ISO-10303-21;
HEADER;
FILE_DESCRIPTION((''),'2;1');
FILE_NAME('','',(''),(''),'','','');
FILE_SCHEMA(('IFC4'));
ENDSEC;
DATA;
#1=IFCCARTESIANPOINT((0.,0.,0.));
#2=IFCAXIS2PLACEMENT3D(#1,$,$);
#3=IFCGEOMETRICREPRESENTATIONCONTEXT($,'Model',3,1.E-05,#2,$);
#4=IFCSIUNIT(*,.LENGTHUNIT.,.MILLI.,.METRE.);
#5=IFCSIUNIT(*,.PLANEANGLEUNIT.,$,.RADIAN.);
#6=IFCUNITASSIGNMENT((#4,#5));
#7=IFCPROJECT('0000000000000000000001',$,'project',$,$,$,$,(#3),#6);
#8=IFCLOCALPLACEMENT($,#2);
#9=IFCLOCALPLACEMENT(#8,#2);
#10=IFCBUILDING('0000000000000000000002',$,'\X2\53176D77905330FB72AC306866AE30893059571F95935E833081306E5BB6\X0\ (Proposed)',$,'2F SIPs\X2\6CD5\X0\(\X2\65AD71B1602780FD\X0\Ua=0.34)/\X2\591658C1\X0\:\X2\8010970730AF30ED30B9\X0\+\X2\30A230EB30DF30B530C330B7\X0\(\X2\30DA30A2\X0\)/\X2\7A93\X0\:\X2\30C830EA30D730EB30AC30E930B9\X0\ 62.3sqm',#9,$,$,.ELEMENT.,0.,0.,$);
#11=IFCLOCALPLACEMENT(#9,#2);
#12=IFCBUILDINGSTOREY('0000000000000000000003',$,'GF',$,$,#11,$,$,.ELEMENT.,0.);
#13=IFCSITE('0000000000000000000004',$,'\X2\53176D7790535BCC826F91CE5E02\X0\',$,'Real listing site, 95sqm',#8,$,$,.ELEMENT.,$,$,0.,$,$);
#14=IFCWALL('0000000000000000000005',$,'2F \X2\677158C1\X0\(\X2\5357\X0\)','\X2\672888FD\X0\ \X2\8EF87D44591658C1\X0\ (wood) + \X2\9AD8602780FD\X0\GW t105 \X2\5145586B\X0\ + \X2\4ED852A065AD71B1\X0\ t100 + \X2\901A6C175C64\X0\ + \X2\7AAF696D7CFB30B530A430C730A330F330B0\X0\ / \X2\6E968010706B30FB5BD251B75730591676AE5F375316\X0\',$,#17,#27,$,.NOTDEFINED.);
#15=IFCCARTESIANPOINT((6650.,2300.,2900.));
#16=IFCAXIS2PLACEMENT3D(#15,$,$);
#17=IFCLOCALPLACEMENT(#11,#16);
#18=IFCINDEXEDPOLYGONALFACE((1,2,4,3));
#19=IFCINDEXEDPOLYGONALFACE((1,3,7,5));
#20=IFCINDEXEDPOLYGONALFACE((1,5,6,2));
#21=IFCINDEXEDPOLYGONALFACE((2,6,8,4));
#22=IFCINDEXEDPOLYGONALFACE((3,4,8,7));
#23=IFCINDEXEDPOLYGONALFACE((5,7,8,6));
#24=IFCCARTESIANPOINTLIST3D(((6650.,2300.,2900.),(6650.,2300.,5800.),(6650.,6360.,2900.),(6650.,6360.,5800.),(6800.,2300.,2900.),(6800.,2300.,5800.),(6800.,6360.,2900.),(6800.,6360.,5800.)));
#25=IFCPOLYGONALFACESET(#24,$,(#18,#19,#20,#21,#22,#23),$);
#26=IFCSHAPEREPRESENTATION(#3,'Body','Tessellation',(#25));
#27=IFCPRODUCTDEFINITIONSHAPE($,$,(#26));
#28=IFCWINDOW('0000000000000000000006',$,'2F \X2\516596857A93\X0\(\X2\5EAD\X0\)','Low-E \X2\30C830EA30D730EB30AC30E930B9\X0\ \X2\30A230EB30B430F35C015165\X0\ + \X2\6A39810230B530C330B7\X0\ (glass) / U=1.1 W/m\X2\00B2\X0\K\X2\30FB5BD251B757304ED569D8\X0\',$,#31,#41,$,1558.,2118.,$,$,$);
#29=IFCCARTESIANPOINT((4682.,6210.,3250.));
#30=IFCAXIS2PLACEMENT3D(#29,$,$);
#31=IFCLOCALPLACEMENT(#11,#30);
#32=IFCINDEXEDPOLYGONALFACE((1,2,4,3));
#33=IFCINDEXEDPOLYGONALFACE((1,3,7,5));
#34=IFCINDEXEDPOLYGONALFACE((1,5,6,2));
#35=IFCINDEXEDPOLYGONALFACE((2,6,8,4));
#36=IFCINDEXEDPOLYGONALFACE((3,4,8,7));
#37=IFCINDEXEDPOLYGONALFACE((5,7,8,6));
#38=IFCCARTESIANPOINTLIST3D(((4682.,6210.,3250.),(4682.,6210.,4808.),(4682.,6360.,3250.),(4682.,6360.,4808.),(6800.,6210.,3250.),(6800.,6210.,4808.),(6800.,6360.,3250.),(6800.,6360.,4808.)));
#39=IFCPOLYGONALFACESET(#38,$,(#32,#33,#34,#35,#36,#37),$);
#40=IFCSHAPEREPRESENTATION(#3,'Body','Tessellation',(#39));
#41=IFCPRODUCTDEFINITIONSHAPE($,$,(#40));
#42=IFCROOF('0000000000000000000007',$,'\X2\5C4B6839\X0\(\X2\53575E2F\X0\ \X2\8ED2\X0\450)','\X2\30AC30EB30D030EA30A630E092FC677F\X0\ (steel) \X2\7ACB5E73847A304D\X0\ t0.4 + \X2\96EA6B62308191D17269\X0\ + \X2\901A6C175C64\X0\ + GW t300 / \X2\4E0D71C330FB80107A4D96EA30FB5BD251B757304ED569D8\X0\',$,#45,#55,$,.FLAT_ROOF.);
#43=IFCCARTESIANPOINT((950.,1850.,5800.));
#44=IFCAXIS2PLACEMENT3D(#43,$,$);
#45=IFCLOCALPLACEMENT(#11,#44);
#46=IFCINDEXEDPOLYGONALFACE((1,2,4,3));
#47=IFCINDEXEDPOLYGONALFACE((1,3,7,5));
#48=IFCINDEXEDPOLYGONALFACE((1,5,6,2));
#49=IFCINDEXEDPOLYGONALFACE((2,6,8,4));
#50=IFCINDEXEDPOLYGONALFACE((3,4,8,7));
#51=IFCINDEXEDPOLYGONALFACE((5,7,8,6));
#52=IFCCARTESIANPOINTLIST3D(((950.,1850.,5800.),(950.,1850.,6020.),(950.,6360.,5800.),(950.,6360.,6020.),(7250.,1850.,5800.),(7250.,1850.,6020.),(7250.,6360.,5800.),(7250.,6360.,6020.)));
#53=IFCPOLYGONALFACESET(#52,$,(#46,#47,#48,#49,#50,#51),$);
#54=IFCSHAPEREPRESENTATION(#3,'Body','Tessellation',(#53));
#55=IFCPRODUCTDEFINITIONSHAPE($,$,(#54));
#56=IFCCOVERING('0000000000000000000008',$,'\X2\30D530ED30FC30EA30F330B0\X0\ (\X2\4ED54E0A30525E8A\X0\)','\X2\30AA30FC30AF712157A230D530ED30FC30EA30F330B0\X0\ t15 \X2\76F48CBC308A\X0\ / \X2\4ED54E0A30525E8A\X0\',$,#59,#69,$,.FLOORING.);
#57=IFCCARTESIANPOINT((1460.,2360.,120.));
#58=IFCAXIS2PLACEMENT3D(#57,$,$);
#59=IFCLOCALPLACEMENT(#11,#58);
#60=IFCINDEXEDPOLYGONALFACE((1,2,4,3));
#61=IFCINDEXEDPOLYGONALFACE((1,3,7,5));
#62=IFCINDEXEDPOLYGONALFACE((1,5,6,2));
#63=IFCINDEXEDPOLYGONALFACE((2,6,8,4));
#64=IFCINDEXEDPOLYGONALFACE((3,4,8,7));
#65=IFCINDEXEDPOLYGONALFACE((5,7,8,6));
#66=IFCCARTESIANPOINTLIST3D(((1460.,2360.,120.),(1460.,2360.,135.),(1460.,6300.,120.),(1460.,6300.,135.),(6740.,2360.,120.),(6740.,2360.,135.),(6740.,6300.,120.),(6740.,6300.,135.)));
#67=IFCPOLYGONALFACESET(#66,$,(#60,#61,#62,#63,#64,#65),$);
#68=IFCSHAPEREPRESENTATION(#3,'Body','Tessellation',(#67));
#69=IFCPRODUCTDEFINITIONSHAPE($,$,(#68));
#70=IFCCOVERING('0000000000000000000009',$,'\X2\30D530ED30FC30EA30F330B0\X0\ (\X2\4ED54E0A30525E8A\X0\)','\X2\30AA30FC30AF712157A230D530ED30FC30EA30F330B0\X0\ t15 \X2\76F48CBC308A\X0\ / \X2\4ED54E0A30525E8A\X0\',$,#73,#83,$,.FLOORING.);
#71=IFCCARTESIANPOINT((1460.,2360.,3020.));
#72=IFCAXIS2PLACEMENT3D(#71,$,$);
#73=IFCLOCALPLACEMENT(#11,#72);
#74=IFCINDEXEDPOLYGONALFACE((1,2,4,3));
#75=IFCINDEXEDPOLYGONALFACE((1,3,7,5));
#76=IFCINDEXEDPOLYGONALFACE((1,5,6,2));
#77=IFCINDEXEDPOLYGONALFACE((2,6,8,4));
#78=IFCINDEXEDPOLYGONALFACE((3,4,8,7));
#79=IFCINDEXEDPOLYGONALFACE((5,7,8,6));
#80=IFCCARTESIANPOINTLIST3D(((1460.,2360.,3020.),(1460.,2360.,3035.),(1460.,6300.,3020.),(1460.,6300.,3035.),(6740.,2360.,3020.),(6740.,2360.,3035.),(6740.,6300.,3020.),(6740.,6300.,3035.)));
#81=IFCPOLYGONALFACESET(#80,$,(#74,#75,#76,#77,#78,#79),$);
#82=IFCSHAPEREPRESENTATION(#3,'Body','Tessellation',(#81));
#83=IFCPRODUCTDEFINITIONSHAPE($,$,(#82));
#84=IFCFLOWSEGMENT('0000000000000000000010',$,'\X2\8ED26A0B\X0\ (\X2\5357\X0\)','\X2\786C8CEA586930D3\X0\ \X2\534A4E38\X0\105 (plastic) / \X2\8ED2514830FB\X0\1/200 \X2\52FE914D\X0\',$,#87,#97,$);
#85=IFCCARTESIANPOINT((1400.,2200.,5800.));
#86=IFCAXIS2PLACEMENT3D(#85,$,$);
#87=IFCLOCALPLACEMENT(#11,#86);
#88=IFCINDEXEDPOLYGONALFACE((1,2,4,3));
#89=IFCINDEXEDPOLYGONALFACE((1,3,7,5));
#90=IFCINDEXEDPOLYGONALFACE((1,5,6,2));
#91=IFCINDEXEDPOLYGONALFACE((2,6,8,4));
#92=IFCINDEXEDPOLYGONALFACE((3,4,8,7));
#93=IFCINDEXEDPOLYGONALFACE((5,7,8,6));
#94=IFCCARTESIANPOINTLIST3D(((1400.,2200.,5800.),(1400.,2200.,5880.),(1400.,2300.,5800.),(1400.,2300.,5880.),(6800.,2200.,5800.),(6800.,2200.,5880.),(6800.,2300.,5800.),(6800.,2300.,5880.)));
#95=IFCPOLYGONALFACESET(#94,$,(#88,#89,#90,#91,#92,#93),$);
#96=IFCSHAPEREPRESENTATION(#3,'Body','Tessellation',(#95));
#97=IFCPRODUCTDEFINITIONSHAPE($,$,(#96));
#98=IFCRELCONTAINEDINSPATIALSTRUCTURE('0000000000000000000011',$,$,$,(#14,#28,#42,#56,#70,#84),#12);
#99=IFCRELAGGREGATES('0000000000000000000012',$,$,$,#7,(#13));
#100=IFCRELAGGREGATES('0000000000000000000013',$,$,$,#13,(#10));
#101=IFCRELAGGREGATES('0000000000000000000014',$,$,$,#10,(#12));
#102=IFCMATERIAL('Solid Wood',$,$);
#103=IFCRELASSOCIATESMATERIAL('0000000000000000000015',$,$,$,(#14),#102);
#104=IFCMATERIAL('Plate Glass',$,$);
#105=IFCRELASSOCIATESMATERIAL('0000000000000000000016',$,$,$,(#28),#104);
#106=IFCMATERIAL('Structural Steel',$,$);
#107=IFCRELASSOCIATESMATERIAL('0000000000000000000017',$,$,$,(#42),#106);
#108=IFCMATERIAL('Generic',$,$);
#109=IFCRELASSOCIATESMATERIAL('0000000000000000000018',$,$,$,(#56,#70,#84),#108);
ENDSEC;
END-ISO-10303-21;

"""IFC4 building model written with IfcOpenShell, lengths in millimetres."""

from ifc_helpers import new_model, si_unit, frame, frame_2d, origin, place, context, project, spatial, rectangle, extrude, material, element, fill, save


model = new_model("IFC4")

# Units and contexts
model_context = context("Model", 3, precision=1e-05, world=origin())
ifc_project = project(units=[si_unit("LENGTHUNIT", "METRE", prefix="MILLI"), si_unit("PLANEANGLEUNIT", "RADIAN")], contexts=[model_context])

# Site, building, storey
site_placement = place(None, origin())
site = spatial("IfcSite", under=ifc_project, at=site_placement, Name="北海道富良野市", ObjectType="Real listing site, 95sqm", CompositionType="ELEMENT", RefElevation=0.0)
building_placement = place(site_placement, origin())
building = spatial("IfcBuilding", under=site, at=building_placement, Name="北海道・犬と暮らす土間広めの家 (Proposed)", ObjectType="2F SIPs法(断熱性能Ua=0.34)/外壁:耐震クロス+アルミサッシ(ペア)/窓:トリプルガラス 62.3sqm", CompositionType="ELEMENT", ElevationOfRefHeight=0.0, ElevationOfTerrain=0.0)
storey_placement = place(building_placement, origin())
storey = spatial("IfcBuildingStorey", under=building, at=storey_placement, Name="GF", CompositionType="ELEMENT", Elevation=0.0)

# Shared definitions
ifc_material_1 = material(Name="Solid Wood")

# Wall, opening, window
ifc_material_2 = material(Name="Plate Glass")
wall_1_placement = place(storey_placement, frame((6650.0, 2300.0, 2900.0)))
wall_1 = element("IfcWall", 1, at=wall_1_placement, inside=storey, material=ifc_material_1, Name="2F 東壁(南)", Description="木製 軸組外壁 (wood) + 高性能GW t105 充填 + 付加断熱 t100 + 通気層 + 窯業系サイディング / 準耐火・寒冷地外皮強化", PredefinedType="NOTDEFINED", context=model_context, shape_type="SweptSolid", body=[
    extrude(rectangle(XDim=150.0, YDim=4060.0, at=frame_2d((75.0, 2030.0))), frame((6650.0, 2300.0, 2900.0)), (0.0, 0.0, 1.0), 2900.0),
])
opening_1_placement = place(storey_placement, frame((4682.0, 6210.0, 3250.0)))
opening_1 = element("IfcOpeningElement", 2, at=opening_1_placement, cuts=wall_1, PredefinedType="NOTDEFINED", context=model_context, shape_type="SweptSolid", body=[
    extrude(rectangle(XDim=2118.0, YDim=150.0, at=frame_2d((1059.0, 75.0))), frame((4682.0, 6210.0, 3250.0)), (0.0, 0.0, 1.0), 1558.0),
])
window_1_placement = place(storey_placement, frame((4682.0, 6210.0, 3250.0)))
window_1 = element("IfcWindow", 3, at=window_1_placement, inside=storey, material=ifc_material_2, Name="2F 入隅窓(庭)", Description="Low-E トリプルガラス アルゴン封入 + 樹脂サッシ (glass) / U=1.1 W/m²K・寒冷地仕様", OverallHeight=1558.0, OverallWidth=2118.0, context=model_context, shape_type="SweptSolid", body=[
    extrude(rectangle(XDim=2118.0, YDim=150.0, at=frame_2d((1059.0, 75.0))), frame((4682.0, 6210.0, 3250.0)), (0.0, 0.0, 1.0), 1558.0),
])
fill(opening_1, window_1)

# Roof
ifc_material_3 = material(Name="Structural Steel")
for number, where, name in (
    (4, (950.0, 1850.0, 5800.0), "屋根(南帯 軒450)"),
):
    element("IfcRoof", number, at=place(storey_placement, frame(where)), inside=storey, material=ifc_material_3, Name=name, Description="ガルバリウム鋼板 (steel) 立平葺き t0.4 + 雪止め金物 + 通気層 + GW t300 / 不燃・耐積雪・寒冷地仕様", PredefinedType="FLAT_ROOF", context=model_context, shape_type="SweptSolid", body=[
        extrude(rectangle(XDim=6300.0, YDim=4510.0, at=frame_2d((3150.0, 2255.0))), frame((950.0, 1850.0, 5800.0)), (0.0, 0.0, 1.0), 220.0),
    ])

# Coverings
ifc_material_4 = material(Name="Generic")
covering_1_placement = place(storey_placement, frame((1460.0, 2360.0, 120.0)))
element("IfcCovering", 5, at=covering_1_placement, inside=storey, material=ifc_material_4, Name="フローリング (仕上げ床)", Description="オーク無垢フローリング t15 直貼り / 仕上げ床", PredefinedType="FLOORING", context=model_context, shape_type="SweptSolid", body=[
    extrude(rectangle(XDim=5280.0, YDim=3940.0, at=frame_2d((2640.0, 1970.0))), frame((1460.0, 2360.0, 120.0)), (0.0, 0.0, 1.0), 15.0),
])
covering_2_placement = place(storey_placement, frame((1460.0, 2360.0, 3020.0)))
element("IfcCovering", 6, at=covering_2_placement, inside=storey, material=ifc_material_4, Name="フローリング (仕上げ床)", Description="オーク無垢フローリング t15 直貼り / 仕上げ床", PredefinedType="FLOORING", context=model_context, shape_type="SweptSolid", body=[
    extrude(rectangle(XDim=5280.0, YDim=3940.0, at=frame_2d((2640.0, 1970.0))), frame((1460.0, 2360.0, 3020.0)), (0.0, 0.0, 1.0), 15.0),
])

# Flow segment
flow_segment_placement = place(storey_placement, frame((1400.0, 2200.0, 5800.0)))
element("IfcFlowSegment", 7, at=flow_segment_placement, inside=storey, material=ifc_material_4, Name="軒樋 (南)", Description="硬質塩ビ 半丸105 (plastic) / 軒先・1/200 勾配", context=model_context, shape_type="SweptSolid", body=[
    extrude(rectangle(XDim=5400.0, YDim=100.0, at=frame_2d((2700.0, 50.0))), frame((1400.0, 2200.0, 5800.0)), (0.0, 0.0, 1.0), 80.0),
])

save(model, "model.ifc")
